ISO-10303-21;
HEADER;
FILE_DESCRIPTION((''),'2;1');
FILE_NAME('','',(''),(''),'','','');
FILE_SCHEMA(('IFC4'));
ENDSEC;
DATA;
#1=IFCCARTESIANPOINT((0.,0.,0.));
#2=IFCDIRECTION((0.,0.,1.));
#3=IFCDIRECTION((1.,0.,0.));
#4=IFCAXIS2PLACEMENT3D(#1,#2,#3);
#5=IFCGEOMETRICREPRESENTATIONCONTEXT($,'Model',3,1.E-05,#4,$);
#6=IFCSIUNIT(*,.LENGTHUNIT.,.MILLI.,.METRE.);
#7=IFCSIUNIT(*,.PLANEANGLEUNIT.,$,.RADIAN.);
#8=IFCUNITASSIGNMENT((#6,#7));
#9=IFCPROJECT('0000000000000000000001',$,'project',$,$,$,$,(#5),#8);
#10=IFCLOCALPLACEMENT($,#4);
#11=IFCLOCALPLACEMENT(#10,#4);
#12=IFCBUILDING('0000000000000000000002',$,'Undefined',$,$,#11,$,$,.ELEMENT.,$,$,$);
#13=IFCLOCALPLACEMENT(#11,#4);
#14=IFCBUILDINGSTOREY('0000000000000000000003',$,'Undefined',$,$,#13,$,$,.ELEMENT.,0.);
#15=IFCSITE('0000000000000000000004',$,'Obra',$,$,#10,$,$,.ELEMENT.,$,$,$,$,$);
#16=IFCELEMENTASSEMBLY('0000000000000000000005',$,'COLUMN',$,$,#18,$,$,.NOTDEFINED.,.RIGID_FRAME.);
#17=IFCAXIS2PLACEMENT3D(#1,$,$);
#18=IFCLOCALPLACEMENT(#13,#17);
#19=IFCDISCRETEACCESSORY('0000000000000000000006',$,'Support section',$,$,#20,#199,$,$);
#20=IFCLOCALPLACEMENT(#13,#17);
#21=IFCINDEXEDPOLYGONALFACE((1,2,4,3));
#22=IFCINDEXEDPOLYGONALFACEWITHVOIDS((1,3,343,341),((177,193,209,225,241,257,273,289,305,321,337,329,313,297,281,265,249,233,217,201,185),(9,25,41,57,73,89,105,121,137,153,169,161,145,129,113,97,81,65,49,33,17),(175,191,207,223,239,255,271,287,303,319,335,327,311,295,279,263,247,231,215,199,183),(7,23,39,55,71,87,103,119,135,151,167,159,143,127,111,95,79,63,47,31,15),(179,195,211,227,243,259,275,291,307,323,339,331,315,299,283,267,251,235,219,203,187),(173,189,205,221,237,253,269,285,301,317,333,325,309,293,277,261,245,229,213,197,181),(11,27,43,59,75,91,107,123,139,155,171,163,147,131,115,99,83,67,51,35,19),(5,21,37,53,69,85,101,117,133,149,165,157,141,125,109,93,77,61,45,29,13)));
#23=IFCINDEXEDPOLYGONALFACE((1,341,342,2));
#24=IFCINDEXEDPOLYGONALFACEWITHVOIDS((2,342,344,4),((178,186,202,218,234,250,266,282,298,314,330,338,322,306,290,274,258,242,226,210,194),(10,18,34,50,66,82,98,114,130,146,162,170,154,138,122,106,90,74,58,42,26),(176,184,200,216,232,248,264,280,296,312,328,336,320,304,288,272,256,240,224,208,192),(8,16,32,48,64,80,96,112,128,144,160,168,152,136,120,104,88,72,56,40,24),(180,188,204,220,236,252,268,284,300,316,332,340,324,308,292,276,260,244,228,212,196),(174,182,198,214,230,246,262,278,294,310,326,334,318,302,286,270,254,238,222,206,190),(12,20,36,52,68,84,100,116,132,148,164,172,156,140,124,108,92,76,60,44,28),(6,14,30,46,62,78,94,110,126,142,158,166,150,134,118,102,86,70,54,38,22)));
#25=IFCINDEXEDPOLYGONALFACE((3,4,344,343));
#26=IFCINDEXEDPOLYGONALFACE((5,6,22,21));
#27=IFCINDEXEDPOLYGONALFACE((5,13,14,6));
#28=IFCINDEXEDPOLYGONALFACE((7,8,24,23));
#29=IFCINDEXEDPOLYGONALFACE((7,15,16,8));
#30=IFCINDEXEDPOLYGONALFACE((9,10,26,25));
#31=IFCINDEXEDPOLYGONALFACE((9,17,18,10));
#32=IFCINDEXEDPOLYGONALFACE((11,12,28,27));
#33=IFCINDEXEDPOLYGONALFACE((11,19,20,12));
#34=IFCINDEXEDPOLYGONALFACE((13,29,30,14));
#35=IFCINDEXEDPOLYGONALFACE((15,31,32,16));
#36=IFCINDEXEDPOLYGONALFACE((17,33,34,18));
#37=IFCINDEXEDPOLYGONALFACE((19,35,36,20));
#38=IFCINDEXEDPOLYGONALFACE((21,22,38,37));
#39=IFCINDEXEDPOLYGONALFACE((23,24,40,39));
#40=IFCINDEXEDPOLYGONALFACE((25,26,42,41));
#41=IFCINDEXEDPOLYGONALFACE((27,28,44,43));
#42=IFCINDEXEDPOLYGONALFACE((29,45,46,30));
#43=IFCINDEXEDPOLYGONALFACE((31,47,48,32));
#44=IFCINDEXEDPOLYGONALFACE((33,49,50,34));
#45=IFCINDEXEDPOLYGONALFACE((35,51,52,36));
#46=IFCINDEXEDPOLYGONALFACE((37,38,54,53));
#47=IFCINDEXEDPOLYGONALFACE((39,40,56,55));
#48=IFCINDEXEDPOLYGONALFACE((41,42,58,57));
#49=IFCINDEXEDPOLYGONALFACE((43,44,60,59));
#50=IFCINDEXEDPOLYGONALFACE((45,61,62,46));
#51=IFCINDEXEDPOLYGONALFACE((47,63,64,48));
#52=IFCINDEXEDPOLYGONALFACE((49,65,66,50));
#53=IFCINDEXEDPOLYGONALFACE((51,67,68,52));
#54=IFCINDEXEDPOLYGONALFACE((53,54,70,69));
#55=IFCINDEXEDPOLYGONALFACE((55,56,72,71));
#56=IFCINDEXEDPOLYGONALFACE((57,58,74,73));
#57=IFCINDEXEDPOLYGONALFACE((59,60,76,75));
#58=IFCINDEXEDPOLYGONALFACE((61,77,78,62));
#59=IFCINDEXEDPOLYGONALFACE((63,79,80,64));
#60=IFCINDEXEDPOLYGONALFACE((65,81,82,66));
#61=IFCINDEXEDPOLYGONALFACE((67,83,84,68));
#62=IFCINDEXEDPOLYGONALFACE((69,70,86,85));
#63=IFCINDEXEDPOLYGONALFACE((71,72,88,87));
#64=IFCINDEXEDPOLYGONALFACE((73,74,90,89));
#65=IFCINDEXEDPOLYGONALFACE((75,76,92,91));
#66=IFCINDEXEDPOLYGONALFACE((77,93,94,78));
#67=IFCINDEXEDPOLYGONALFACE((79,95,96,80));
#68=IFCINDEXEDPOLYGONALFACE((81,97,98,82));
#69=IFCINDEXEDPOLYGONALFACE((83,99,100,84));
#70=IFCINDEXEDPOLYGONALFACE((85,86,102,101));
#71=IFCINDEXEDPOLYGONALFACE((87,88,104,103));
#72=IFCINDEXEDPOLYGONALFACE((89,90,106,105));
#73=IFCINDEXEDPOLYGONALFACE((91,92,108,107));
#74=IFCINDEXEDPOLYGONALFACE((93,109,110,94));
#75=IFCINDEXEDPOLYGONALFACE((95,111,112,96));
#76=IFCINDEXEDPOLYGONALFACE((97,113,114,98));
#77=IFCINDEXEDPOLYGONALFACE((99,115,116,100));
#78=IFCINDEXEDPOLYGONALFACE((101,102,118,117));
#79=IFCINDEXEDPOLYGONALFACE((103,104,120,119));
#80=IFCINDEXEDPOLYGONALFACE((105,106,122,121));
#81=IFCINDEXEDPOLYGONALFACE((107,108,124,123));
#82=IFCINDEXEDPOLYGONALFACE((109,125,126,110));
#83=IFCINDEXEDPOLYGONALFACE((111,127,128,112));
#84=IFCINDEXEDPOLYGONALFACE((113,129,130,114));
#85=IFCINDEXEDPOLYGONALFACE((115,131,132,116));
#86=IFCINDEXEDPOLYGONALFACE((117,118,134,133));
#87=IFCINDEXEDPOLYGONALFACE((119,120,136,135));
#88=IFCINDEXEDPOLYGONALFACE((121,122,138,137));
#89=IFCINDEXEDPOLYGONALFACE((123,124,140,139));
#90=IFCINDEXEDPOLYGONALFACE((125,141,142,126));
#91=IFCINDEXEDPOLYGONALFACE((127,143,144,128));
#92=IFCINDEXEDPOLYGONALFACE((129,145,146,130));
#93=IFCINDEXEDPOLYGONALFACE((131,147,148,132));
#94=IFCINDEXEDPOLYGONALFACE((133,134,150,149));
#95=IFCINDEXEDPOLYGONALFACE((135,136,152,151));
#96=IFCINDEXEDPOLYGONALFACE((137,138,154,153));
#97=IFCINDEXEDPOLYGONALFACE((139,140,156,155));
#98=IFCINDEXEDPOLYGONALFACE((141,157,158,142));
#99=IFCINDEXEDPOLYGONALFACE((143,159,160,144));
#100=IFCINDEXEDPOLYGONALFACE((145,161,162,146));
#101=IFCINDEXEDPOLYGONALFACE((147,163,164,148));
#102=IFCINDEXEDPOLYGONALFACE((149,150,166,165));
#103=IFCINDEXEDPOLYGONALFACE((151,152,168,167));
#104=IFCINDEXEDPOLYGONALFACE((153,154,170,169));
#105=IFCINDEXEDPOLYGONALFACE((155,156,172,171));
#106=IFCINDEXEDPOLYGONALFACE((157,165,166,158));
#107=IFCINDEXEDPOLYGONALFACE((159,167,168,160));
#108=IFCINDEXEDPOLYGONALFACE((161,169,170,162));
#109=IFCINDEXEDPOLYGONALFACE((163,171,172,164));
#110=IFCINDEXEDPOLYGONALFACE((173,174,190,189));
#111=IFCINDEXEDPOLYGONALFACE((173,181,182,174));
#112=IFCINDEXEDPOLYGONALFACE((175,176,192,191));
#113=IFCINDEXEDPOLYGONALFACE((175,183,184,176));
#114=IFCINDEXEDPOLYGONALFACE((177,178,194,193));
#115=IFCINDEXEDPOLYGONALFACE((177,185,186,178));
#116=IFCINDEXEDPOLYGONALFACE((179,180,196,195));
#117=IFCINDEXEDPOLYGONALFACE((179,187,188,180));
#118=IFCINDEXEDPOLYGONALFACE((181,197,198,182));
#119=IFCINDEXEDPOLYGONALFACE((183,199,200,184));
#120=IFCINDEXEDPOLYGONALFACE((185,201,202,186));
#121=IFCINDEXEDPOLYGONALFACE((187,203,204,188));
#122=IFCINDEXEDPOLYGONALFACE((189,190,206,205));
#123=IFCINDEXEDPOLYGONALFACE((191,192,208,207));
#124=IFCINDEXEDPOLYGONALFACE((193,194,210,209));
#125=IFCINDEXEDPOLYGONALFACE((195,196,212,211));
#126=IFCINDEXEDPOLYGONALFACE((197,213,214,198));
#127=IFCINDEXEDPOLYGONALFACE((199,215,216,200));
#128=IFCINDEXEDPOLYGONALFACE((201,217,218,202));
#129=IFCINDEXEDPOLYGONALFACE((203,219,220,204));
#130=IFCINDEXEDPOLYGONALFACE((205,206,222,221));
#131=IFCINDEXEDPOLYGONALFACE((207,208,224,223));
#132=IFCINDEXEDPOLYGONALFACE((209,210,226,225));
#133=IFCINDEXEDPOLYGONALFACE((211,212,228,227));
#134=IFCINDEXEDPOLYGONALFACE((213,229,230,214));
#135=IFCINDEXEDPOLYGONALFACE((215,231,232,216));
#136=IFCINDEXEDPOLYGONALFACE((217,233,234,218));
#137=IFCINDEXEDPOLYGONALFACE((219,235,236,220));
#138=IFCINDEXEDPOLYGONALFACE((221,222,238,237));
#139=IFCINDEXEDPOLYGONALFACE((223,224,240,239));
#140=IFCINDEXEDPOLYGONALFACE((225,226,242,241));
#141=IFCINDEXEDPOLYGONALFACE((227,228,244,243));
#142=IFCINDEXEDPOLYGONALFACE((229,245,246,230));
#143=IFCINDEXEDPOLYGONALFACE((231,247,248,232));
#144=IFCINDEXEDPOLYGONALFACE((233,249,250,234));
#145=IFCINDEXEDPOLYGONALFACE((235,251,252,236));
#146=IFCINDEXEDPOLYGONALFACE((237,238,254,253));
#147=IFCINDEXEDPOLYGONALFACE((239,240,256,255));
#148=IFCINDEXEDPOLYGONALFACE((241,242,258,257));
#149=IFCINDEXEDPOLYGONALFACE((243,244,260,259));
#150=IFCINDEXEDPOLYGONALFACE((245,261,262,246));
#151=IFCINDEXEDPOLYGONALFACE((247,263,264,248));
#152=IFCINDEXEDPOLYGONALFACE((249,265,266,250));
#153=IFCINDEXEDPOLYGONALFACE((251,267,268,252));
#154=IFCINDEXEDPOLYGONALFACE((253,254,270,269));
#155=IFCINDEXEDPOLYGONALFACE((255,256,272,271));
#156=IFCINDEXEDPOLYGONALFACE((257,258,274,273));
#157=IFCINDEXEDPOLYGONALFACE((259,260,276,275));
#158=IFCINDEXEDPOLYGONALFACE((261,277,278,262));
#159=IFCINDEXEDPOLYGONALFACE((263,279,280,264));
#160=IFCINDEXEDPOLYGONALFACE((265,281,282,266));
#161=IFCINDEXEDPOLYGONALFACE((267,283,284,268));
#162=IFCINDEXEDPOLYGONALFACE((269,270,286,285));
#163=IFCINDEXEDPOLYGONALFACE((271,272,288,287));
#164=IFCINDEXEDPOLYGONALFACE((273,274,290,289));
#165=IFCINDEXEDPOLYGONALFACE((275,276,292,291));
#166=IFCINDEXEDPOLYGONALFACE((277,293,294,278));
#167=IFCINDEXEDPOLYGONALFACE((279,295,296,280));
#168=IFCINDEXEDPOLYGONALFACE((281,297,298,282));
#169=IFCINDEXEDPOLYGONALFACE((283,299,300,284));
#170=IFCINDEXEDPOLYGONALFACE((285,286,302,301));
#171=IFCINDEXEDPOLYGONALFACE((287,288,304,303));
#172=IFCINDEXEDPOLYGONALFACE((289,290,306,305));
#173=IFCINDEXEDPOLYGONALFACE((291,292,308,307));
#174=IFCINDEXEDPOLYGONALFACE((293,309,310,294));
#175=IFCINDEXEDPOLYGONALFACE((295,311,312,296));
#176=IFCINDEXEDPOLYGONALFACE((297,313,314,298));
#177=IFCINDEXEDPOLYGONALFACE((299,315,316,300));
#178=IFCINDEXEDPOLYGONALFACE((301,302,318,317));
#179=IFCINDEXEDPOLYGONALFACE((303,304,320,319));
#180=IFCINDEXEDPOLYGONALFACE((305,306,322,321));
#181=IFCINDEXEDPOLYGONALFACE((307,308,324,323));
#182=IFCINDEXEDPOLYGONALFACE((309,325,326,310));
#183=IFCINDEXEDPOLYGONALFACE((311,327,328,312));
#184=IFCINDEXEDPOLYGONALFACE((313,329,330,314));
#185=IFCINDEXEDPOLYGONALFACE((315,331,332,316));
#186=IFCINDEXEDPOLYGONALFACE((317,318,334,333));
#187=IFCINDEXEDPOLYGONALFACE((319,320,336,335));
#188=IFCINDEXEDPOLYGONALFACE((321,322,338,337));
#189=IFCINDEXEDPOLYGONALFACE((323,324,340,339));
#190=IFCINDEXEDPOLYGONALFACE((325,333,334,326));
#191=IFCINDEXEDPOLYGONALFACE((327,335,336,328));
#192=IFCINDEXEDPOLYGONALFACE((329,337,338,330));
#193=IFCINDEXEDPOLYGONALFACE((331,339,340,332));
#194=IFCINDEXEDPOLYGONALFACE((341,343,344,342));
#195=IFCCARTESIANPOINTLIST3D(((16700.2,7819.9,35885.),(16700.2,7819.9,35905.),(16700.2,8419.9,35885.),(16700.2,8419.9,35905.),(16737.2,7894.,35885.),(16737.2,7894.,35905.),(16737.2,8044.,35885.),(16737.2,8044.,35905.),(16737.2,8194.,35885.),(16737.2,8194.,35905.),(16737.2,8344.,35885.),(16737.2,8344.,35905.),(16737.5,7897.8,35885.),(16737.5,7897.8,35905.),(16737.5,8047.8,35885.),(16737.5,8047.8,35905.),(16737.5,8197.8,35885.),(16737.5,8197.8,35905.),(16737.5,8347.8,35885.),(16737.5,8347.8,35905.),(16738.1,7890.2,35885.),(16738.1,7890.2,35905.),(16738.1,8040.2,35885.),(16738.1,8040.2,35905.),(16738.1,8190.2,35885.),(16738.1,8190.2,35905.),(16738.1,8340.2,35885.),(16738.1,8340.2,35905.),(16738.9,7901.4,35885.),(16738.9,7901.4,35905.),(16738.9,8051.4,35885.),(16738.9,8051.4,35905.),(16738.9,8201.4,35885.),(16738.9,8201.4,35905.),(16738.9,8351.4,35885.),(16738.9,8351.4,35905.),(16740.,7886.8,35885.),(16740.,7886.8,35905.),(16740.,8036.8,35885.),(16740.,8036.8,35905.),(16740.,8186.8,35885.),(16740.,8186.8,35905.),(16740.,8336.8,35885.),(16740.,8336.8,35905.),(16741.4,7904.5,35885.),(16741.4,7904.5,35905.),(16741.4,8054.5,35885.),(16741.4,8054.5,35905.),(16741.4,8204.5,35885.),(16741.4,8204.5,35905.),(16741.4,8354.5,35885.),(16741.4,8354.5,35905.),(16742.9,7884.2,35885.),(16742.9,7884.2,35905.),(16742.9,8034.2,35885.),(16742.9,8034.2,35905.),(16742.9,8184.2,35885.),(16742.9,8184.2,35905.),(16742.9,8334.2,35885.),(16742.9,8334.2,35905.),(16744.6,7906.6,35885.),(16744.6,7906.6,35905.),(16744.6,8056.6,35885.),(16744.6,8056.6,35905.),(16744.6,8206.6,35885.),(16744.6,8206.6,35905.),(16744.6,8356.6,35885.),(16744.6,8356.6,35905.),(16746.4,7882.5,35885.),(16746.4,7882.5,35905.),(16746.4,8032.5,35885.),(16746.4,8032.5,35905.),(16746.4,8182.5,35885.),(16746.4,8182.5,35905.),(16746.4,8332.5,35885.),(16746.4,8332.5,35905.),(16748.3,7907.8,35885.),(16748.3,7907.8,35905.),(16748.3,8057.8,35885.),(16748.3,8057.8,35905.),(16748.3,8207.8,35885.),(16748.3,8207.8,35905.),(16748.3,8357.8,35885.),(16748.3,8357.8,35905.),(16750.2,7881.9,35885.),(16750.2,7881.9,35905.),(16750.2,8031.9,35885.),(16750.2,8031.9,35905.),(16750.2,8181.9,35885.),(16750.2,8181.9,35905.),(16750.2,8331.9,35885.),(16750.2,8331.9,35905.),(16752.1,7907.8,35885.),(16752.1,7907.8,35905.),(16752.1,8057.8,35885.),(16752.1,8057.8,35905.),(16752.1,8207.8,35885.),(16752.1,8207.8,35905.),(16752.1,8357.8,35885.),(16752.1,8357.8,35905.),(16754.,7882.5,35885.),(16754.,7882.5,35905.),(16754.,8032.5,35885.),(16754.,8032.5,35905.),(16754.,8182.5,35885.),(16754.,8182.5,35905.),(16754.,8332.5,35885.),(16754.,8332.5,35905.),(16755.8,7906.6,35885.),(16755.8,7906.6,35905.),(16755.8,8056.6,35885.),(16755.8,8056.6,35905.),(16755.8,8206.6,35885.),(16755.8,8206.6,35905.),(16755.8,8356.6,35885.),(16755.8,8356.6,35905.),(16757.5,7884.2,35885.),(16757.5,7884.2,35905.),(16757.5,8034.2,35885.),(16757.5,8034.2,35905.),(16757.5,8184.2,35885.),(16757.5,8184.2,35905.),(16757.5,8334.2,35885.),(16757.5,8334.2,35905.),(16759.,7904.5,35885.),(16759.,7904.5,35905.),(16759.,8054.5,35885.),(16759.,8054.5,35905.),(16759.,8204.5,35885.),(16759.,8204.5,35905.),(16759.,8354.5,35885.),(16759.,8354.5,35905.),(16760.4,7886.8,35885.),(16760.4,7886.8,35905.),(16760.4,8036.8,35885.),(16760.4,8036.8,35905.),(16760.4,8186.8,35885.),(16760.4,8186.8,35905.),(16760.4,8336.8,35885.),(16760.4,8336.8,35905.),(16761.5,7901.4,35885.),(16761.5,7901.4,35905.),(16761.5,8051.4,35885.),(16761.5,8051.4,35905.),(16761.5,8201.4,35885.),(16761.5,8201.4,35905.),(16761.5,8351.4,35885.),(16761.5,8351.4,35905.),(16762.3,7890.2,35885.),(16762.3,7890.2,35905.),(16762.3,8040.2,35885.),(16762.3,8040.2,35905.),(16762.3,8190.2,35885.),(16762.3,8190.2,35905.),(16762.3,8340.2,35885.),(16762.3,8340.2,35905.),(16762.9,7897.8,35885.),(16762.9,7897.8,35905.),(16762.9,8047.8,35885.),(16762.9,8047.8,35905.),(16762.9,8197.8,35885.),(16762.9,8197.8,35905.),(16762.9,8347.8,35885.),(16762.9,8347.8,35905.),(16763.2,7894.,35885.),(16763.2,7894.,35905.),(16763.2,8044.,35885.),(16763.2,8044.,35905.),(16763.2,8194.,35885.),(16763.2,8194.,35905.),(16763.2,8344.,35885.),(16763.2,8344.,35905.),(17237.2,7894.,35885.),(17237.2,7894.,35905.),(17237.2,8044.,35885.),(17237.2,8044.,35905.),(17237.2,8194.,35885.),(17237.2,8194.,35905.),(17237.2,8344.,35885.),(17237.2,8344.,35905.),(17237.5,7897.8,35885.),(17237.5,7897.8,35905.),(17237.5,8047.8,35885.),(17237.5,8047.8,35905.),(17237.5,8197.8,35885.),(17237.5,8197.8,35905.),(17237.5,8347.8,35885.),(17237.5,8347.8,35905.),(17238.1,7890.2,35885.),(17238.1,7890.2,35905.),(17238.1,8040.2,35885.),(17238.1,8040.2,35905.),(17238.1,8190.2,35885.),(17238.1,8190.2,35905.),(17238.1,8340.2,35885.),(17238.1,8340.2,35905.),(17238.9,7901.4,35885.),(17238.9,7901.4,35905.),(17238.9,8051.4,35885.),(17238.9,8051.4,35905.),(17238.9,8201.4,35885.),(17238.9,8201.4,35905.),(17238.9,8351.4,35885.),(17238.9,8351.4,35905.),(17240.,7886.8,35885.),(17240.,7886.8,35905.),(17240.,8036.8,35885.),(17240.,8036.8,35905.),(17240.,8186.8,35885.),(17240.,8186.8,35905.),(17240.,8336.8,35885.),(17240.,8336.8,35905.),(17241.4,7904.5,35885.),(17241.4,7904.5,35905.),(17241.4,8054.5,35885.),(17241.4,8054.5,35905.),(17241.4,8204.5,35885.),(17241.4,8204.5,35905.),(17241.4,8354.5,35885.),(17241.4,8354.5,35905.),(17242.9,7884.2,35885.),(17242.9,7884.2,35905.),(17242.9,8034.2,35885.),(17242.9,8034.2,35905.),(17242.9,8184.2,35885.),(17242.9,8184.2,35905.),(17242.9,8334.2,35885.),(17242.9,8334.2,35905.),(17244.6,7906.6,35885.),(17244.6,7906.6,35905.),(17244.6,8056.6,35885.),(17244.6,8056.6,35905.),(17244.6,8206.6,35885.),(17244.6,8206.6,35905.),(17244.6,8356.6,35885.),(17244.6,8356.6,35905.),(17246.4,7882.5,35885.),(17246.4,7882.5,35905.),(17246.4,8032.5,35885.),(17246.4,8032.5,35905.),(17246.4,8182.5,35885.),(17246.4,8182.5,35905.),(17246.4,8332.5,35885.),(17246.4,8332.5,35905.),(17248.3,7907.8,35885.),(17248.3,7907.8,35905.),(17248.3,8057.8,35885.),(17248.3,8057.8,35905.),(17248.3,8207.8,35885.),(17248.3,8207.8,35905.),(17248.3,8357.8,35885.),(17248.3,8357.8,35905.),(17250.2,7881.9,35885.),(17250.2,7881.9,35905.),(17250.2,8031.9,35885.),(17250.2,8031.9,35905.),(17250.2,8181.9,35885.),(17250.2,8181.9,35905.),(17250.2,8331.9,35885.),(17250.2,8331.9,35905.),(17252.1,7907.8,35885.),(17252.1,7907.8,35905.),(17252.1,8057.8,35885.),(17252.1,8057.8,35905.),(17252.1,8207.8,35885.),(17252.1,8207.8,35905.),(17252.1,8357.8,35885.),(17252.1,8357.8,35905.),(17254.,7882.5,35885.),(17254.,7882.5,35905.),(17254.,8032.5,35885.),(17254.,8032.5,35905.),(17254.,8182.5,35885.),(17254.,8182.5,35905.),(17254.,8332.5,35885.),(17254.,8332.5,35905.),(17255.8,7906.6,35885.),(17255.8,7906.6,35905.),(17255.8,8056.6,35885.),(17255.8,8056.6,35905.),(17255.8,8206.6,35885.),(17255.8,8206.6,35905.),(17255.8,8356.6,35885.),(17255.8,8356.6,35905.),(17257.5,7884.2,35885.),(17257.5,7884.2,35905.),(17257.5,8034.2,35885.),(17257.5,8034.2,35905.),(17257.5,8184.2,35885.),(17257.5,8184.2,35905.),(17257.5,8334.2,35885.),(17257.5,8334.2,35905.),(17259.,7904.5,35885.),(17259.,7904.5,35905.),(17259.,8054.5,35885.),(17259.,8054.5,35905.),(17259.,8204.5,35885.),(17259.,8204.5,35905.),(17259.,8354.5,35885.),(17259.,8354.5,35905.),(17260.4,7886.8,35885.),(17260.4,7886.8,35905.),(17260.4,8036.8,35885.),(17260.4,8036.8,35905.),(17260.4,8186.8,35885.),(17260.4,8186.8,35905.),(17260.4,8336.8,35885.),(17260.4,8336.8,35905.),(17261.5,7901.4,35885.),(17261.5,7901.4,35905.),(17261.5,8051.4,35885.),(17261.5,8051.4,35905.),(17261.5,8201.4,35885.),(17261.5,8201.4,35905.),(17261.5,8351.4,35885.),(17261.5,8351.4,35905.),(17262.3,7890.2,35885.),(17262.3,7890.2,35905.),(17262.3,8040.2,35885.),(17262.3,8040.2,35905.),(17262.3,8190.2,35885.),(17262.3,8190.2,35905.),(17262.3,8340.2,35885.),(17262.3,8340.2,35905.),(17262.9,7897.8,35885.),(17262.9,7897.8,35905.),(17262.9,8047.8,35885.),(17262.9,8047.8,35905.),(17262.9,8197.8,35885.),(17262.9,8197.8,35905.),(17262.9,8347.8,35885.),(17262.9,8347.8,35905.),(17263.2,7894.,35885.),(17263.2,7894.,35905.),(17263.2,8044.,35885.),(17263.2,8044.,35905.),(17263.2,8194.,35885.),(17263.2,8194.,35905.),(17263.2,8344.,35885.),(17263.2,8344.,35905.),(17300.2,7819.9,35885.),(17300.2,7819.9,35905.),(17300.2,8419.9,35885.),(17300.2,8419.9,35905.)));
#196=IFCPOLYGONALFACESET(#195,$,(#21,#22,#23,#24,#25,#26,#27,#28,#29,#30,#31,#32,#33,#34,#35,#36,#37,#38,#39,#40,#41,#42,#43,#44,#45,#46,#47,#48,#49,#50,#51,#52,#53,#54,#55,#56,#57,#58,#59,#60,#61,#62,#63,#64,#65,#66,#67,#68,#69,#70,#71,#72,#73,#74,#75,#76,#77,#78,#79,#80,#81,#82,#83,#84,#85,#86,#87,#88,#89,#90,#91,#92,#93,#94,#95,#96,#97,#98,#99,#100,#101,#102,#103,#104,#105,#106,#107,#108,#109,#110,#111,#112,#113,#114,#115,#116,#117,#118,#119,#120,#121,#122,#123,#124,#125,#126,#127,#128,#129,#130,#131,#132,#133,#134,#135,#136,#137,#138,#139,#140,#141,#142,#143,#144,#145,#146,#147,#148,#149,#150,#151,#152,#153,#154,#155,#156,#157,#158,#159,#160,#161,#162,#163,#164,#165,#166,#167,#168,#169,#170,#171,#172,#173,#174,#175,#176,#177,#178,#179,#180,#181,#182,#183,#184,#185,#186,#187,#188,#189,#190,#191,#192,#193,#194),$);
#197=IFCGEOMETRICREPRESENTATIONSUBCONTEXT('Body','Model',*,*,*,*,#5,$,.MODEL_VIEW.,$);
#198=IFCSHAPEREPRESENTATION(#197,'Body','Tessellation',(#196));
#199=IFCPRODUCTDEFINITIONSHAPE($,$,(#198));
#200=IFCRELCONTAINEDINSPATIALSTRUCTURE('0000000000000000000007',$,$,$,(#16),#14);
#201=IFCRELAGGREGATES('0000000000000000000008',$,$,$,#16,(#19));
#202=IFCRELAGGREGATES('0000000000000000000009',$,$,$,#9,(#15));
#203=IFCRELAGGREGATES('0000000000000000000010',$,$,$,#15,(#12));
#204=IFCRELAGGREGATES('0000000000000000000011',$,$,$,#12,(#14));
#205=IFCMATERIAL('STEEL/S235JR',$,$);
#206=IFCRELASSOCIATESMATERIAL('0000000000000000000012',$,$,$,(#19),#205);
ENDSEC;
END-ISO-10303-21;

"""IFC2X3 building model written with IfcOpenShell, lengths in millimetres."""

from ifc_helpers import new_model, si_unit, frame, origin_with_axes, origin_2d_with_axis, place, context, subcontext, project, spatial, rectangle, circle, extrude, source, transform, mapped, material, element, aggregate, save


model = new_model("IFC2X3")

# Units and contexts
model_context = context("Model", 3, precision=1e-05, world=origin_with_axes())
body_context = subcontext(model_context, "Body", "Model", "MODEL_VIEW")
ifc_project = project(units=[si_unit("LENGTHUNIT", "METRE", prefix="MILLI"), si_unit("PLANEANGLEUNIT", "RADIAN")], contexts=[model_context])

# Site, building, storey
site_placement = place(None, origin_with_axes())
site = spatial("IfcSite", under=ifc_project, at=site_placement, Name="Obra", CompositionType="ELEMENT")
building_placement = place(site_placement, origin_with_axes())
building = spatial("IfcBuilding", under=site, at=building_placement, Name="Undefined", CompositionType="ELEMENT")
storey_placement = place(building_placement, origin_with_axes())
storey = spatial("IfcBuildingStorey", under=building, at=storey_placement, Name="Undefined", CompositionType="ELEMENT", Elevation=0.0)

# Element assembly
assembly_1_placement = place(storey_placement, origin_with_axes())
assembly_1 = element("IfcElementAssembly", 1, at=assembly_1_placement, inside=storey, Name="COLUMN", AssemblyPlace="NOTDEFINED", PredefinedType="RIGID_FRAME")
ifc_material_1 = material(Name="STEEL/S235JR")

# Discrete accessory, opening
discrete_accessory_1_placement = place(assembly_1_placement, frame((17000.2, 7819.9, 35895.0), z_axis=(1.0, 0.0, 0.0), x_axis=(0.0, 1.0, 0.0)))
discrete_accessory_1 = element("IfcDiscreteAccessory", 2, at=discrete_accessory_1_placement, material=ifc_material_1, Name="Support section", context=body_context, shape_type="SweptSolid", body=[
    extrude(rectangle(XDim=20.0, YDim=600.0, at=origin_2d_with_axis()), frame((600.0, 0.0, 0.0), z_axis=(-1.0, 0.0, 0.0), x_axis=(0.0, -1.0, 0.0)), (0.0, 0.0, 1.0), 600.0),
])
shared_shape_1 = source(origin_with_axes(), body_context, "Body", "SweptSolid", [
    extrude(circle(Radius=13.0, at=origin_2d_with_axis()), frame((0.0, -0.1, 0.0), z_axis=(0.0, 1.0, 0.0), x_axis=(1.0, 0.0, 0.0)), (0.0, 0.0, 1.0), 20.2),
])
opening_1_placement = place(assembly_1_placement, frame((17000.2, 8322.9, 35905.0), z_axis=(1.0, 0.0, 0.0), x_axis=(0.0, -1.0, 0.0)))
element("IfcOpeningElement", 3, at=opening_1_placement, cuts=discrete_accessory_1, ObjectType="Opening", context=body_context, shape_type="MappedRepresentation", body=[
    mapped(shared_shape_1, transform((-22.0, 0.0, -250.0))),
    mapped(shared_shape_1, transform((-22.0, 0.0, 250.0))),
    mapped(shared_shape_1, transform((128.0, 0.0, -250.0))),
    mapped(shared_shape_1, transform((128.0, 0.0, 250.0))),
    mapped(shared_shape_1, transform((278.0, 0.0, -250.0))),
    mapped(shared_shape_1, transform((278.0, 0.0, 250.0))),
    mapped(shared_shape_1, transform((428.0, 0.0, -250.0))),
    mapped(shared_shape_1, transform((428.0, 0.0, 250.0))),
])
aggregate(assembly_1, [discrete_accessory_1])

save(model, "model.ifc")
